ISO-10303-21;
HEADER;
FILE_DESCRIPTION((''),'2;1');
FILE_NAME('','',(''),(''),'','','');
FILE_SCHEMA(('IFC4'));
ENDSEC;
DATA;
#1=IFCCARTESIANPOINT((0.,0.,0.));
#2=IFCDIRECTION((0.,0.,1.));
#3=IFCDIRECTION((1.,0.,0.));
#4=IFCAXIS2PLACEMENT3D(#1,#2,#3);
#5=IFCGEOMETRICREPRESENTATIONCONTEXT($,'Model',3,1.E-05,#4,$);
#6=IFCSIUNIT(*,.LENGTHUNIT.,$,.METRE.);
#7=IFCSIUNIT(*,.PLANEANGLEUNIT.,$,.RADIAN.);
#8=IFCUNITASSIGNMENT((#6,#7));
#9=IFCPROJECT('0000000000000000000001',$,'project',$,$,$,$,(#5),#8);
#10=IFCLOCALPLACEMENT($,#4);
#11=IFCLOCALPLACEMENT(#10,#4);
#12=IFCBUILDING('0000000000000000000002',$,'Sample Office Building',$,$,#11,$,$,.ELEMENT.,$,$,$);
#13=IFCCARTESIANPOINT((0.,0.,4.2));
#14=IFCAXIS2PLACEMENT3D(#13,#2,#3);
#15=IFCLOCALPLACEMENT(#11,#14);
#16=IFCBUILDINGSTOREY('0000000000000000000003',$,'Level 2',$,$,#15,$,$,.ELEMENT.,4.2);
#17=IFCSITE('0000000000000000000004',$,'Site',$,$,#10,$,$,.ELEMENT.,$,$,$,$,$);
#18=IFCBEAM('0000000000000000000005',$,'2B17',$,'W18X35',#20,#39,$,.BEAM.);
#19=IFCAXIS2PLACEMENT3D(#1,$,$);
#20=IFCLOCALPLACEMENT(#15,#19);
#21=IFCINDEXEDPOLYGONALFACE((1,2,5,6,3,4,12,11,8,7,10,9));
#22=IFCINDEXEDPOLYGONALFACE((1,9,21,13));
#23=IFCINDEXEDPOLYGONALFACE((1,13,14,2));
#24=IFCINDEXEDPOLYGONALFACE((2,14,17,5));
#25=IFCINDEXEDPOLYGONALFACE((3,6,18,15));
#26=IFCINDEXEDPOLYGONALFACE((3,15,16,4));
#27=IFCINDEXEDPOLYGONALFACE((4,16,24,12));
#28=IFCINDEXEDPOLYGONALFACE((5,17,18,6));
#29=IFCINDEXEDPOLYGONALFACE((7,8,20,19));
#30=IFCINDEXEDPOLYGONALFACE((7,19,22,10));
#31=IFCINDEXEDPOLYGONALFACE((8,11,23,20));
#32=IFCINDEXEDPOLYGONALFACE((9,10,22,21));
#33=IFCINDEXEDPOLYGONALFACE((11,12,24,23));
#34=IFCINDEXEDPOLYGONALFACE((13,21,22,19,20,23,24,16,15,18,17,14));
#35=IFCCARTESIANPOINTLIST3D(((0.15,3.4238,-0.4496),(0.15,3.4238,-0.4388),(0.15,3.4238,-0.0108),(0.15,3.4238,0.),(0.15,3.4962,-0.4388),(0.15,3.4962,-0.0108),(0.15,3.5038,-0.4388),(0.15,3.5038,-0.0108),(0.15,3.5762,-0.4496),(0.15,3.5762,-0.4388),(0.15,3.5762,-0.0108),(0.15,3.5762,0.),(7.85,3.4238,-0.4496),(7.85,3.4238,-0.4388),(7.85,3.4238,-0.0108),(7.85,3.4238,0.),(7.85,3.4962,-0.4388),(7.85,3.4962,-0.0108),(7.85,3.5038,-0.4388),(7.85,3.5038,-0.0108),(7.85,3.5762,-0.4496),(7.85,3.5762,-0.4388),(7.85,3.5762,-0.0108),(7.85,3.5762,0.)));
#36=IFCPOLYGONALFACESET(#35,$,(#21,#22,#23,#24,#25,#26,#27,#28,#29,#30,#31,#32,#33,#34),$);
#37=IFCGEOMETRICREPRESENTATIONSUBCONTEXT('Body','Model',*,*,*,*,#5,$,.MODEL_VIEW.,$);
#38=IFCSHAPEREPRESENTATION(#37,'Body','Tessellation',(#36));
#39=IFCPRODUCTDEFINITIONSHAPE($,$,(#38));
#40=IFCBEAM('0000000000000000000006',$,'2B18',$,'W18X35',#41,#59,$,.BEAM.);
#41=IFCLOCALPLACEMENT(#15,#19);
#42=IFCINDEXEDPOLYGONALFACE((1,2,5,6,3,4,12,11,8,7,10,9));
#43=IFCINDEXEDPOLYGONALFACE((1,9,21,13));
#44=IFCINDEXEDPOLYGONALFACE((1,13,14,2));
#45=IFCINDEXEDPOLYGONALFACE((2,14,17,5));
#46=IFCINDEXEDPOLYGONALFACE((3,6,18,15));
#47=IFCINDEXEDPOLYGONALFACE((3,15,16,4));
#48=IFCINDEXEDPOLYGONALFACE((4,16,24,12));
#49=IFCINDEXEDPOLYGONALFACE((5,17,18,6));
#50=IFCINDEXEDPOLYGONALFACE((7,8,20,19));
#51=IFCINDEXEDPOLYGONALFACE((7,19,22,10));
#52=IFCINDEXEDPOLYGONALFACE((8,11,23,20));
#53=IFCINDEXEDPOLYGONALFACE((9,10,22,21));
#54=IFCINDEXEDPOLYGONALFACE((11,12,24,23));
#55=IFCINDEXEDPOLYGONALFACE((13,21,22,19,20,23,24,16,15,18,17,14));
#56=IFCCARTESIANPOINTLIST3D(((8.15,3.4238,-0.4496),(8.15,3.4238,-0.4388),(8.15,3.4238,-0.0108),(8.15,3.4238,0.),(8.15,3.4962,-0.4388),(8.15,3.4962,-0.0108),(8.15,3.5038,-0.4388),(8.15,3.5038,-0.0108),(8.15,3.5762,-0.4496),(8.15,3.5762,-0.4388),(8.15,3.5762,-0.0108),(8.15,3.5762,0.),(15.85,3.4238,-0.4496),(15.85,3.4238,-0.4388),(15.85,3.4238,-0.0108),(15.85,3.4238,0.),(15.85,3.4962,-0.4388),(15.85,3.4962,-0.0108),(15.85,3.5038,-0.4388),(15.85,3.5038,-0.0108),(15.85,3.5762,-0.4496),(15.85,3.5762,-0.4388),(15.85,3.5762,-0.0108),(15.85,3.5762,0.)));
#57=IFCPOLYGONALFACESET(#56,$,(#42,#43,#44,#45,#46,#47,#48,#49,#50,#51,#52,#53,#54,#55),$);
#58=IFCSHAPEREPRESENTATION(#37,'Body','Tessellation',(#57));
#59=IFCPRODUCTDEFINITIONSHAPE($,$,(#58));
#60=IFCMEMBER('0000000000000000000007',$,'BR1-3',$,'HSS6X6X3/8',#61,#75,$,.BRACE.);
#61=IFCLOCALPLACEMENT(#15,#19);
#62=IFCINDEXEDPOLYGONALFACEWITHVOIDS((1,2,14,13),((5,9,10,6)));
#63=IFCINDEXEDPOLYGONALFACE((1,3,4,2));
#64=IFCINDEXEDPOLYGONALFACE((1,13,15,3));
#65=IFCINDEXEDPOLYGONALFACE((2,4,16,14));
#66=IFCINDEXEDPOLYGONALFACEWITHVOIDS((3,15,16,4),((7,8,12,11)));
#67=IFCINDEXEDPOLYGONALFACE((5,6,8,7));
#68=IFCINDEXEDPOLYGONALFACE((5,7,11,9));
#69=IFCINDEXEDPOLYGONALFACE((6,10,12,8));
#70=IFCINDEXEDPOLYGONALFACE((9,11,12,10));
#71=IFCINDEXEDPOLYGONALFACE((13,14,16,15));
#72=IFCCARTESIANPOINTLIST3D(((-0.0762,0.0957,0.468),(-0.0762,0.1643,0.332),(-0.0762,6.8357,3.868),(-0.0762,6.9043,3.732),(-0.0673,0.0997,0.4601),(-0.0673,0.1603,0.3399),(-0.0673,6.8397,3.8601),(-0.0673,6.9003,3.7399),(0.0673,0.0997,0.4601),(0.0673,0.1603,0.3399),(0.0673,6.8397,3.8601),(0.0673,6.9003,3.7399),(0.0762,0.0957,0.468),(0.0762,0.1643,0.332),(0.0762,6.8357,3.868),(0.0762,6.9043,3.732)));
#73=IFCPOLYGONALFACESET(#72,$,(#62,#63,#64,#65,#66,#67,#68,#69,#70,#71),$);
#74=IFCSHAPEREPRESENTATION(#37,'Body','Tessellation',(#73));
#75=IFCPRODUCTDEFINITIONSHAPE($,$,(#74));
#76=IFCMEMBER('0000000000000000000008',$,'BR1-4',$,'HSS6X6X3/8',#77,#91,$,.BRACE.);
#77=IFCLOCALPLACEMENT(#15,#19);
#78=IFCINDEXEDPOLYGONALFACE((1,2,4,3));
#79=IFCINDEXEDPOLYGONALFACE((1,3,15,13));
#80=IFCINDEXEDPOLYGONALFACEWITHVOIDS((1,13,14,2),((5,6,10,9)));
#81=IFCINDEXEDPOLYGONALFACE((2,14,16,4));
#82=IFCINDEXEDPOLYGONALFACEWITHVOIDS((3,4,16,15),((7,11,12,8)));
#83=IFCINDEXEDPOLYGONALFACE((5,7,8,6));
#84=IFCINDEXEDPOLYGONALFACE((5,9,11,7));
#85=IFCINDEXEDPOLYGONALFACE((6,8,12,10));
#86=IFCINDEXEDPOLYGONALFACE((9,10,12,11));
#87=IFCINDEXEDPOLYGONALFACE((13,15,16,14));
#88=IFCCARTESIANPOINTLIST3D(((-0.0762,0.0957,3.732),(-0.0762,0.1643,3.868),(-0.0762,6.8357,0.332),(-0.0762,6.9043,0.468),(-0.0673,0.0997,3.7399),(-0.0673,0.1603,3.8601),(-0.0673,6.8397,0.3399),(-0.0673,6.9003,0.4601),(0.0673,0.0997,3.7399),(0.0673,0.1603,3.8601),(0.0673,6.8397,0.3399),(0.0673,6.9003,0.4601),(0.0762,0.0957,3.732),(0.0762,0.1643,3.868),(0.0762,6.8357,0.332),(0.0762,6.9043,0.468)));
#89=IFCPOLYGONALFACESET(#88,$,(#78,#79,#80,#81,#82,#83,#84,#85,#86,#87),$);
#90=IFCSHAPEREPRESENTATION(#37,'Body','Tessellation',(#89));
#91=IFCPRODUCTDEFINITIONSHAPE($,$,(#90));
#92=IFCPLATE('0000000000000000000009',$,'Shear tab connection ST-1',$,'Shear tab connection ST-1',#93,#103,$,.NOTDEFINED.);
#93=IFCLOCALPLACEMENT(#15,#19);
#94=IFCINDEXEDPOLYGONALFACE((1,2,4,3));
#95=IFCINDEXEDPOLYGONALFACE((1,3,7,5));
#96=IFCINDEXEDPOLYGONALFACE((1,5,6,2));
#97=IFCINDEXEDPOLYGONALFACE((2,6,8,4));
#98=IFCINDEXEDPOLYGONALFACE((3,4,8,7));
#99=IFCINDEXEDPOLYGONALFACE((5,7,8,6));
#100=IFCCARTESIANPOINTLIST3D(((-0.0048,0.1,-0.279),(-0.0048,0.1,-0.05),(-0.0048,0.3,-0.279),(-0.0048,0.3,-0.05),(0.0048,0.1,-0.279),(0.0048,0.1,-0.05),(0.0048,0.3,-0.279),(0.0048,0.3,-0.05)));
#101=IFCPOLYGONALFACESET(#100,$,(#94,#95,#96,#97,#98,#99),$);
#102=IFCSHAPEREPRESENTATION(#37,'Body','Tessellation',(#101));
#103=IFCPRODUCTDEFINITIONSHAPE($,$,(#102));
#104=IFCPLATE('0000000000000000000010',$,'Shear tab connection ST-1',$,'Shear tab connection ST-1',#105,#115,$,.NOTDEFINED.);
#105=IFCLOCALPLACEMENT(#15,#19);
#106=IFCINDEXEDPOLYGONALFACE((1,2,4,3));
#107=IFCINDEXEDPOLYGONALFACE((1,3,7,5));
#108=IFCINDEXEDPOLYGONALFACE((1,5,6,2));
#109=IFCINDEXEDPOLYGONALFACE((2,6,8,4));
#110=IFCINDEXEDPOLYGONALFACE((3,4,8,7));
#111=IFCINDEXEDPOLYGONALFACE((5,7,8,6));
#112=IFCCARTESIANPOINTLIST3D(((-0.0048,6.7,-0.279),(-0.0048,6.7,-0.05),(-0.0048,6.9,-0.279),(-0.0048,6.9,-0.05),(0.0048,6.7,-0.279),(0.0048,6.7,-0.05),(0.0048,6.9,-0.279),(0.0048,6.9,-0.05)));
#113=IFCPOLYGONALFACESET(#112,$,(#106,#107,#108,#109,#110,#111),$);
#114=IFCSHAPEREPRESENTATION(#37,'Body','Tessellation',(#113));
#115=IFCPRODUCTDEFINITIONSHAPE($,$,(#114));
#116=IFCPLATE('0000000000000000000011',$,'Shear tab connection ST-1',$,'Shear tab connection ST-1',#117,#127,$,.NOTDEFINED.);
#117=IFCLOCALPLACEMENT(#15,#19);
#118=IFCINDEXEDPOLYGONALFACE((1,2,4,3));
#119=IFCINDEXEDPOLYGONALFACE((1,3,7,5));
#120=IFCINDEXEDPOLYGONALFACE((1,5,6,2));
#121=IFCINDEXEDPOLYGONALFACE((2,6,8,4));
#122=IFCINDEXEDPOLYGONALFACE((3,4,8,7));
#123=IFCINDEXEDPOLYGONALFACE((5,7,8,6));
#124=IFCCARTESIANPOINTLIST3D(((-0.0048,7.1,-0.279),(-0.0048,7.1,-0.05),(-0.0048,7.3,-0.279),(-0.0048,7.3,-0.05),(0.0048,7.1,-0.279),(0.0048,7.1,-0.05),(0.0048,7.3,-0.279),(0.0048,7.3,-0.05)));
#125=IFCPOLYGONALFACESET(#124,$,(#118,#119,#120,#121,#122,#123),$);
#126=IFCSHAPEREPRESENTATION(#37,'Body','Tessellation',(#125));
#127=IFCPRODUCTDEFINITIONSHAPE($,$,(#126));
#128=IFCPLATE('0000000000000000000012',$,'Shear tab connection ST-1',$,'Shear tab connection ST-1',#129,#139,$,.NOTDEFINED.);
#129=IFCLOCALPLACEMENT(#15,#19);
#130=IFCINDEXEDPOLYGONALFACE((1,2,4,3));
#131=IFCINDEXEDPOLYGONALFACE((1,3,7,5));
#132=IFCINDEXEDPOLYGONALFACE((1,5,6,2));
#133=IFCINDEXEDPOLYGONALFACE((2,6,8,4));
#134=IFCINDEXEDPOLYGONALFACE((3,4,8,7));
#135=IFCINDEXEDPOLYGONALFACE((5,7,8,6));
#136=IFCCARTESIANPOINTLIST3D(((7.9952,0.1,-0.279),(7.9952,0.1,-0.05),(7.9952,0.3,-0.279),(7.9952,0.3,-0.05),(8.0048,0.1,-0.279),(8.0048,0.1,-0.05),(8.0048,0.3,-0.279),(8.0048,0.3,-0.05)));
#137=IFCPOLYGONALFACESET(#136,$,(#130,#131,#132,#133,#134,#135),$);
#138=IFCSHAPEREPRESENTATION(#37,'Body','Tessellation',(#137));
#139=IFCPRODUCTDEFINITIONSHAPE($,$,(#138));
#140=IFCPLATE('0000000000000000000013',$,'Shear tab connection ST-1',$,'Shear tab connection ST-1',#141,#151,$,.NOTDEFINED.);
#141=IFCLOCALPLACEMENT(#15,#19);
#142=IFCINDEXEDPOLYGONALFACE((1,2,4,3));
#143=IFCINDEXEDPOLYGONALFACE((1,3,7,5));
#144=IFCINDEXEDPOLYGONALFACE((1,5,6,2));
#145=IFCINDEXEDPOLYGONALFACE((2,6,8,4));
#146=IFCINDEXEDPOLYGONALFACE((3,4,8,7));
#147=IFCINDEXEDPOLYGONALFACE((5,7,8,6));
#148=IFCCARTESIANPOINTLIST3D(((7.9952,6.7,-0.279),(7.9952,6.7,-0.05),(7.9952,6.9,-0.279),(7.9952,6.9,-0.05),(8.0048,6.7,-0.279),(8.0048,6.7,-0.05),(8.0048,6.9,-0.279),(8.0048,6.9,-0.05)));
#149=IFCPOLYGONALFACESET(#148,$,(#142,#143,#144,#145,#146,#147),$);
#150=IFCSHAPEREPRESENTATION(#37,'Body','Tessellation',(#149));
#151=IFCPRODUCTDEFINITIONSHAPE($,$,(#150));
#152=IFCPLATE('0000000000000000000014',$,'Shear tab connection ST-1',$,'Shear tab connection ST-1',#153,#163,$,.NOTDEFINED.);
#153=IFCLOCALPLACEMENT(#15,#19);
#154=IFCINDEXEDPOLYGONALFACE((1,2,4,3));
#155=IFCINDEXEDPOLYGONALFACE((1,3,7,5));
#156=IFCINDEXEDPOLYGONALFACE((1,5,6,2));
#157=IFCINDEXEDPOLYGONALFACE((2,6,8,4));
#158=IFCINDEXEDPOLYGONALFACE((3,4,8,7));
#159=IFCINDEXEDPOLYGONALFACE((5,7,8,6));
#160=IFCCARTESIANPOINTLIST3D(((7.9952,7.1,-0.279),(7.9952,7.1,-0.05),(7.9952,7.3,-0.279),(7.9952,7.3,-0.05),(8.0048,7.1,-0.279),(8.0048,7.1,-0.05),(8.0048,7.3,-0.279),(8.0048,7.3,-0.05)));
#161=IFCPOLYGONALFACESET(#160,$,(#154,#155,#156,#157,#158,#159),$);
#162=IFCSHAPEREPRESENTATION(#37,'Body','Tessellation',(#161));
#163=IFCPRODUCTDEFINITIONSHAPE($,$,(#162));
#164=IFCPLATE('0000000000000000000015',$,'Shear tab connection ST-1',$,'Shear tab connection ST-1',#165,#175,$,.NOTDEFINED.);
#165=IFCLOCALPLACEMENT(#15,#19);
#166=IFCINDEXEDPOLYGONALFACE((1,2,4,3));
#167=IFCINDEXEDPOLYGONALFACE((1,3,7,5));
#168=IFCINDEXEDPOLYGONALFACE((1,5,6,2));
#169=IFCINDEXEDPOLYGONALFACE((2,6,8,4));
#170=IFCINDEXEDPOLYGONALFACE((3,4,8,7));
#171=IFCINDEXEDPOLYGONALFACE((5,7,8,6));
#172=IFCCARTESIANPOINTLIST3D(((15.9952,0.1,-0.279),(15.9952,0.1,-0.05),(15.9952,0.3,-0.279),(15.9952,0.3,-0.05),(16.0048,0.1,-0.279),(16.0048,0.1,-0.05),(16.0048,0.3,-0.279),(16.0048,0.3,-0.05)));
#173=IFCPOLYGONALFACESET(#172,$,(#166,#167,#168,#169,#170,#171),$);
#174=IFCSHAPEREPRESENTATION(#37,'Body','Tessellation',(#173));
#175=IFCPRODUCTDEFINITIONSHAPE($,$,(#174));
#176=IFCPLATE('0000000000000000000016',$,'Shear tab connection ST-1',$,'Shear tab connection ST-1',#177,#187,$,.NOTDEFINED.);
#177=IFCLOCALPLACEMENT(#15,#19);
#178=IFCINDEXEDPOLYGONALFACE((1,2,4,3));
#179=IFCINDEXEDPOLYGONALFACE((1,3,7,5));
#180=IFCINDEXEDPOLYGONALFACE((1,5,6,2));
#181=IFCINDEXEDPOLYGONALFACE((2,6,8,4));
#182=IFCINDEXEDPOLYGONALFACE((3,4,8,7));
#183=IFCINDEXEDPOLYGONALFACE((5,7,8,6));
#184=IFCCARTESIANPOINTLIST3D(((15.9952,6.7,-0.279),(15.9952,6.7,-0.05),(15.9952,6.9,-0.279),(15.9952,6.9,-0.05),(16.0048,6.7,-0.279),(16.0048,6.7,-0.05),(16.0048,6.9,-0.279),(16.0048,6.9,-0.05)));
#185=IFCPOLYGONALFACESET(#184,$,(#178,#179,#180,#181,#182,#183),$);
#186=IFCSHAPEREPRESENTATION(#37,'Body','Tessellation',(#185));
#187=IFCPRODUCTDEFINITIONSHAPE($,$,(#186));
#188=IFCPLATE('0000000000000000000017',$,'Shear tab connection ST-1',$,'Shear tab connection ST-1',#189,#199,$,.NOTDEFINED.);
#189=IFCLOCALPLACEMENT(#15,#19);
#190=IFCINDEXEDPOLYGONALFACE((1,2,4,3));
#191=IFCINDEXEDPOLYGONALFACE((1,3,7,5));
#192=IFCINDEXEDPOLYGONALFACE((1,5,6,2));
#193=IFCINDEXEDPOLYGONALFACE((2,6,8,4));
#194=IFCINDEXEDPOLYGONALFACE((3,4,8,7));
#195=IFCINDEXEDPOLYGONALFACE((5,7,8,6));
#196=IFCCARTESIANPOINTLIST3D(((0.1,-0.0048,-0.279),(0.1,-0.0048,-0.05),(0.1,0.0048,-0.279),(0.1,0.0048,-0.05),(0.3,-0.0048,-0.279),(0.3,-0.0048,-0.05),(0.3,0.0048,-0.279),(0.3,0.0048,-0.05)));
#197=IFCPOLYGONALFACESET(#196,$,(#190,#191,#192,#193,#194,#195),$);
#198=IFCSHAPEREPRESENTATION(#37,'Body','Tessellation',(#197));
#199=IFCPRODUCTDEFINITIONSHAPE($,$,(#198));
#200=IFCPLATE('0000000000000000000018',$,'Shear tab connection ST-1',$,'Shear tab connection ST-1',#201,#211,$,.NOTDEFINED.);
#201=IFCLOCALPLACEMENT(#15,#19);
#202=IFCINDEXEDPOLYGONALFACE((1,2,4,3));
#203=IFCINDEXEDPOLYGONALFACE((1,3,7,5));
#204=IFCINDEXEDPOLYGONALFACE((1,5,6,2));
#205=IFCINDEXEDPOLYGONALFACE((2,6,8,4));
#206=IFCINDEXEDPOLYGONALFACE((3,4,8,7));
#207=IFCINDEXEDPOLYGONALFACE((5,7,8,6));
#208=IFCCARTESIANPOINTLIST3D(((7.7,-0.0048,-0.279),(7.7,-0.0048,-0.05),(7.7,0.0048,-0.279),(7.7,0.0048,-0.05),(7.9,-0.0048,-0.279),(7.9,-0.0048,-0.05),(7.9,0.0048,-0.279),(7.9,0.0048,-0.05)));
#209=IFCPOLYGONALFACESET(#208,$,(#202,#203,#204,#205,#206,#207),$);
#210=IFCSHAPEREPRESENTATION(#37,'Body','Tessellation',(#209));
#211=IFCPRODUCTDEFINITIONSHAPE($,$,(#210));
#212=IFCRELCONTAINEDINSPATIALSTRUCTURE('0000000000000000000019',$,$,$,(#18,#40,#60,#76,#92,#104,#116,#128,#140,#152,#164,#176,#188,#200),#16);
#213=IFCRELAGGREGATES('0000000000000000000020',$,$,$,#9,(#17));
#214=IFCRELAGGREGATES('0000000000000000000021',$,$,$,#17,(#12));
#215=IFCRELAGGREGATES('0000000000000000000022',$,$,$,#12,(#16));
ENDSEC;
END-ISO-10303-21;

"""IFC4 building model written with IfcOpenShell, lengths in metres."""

from ifc_helpers import new_model, si_unit, frame, origin_with_axes, place, context, subcontext, project, spatial, rectangle, hollow_rectangle, i_section, extrude, element, save


model = new_model("IFC4")

# Units and contexts
model_context = context("Model", 3, precision=1e-05, world=origin_with_axes())
body_context = subcontext(model_context, "Body", "Model", "MODEL_VIEW")
ifc_project = project(units=[si_unit("LENGTHUNIT", "METRE"), si_unit("PLANEANGLEUNIT", "RADIAN")], contexts=[model_context])

# Site, building, storey
site_placement = place(None, origin_with_axes())
site = spatial("IfcSite", under=ifc_project, at=site_placement, Name="Site", CompositionType="ELEMENT")
building_placement = place(site_placement, origin_with_axes())
building = spatial("IfcBuilding", under=site, at=building_placement, Name="Sample Office Building", CompositionType="ELEMENT")
storey_placement = place(building_placement, frame((0.0, 0.0, 4.2), z_axis=(0.0, 0.0, 1.0), x_axis=(1.0, 0.0, 0.0)))
storey = spatial("IfcBuildingStorey", under=building, at=storey_placement, Name="Level 2", CompositionType="ELEMENT", Elevation=4.2)

# Beams
for number, where, z_axis, x_axis, name in (
    (1, (0.15, 3.5, 3.9752), (1.0, 0.0, 0.0), (0.0, 1.0, 0.0), "2B17"),
    (2, (8.15, 3.5, 3.9752), (1.0, 0.0, 0.0), (0.0, 1.0, 0.0), "2B18"),
):
    element("IfcBeam", number, at=place(None, frame(where, z_axis=z_axis, x_axis=x_axis)), inside=storey, Name=name, ObjectType="W18X35", PredefinedType="BEAM", context=body_context, shape_type="SweptSolid", body=[
        extrude(i_section(OverallWidth=0.1524, OverallDepth=0.4496, WebThickness=0.0076, FlangeThickness=0.0108), None, (0.0, 0.0, 1.0), 7.7),
    ])

# Members
for number, where, z_axis, x_axis, name in (
    (3, (0.0, 0.13, 4.6), (0.0, 0.892832, 0.45039), (-1.0, 0.0, 0.0), "BR1-3"),
    (4, (0.0, 6.87, 4.6), (0.0, -0.892832, 0.45039), (1.0, 0.0, 0.0), "BR1-4"),
):
    element("IfcMember", number, at=place(None, frame(where, z_axis=z_axis, x_axis=x_axis)), inside=storey, Name=name, ObjectType="HSS6X6X3/8", PredefinedType="BRACE", context=body_context, shape_type="SweptSolid", body=[
        extrude(hollow_rectangle(XDim=0.1524, YDim=0.1524, WallThickness=0.0089), None, (0.0, 0.0, 1.0), 7.549),
    ])

# Plates
plate_1_placement = place(None, frame((0.0, 0.2, 3.921), z_axis=(0.0, 0.0, 1.0), x_axis=(1.0, 0.0, 0.0)))
element("IfcPlate", 5, at=plate_1_placement, inside=storey, Name="Shear tab connection ST-1", ObjectType="Shear tab connection ST-1", PredefinedType="NOTDEFINED", context=body_context, shape_type="SweptSolid", body=[
    extrude(rectangle(XDim=0.0095, YDim=0.2), None, (0.0, 0.0, 1.0), 0.229),
])
for number, where, z_axis, x_axis, name in (
    (6, (0.0, 6.8, 3.921), (0.0, 0.0, 1.0), (1.0, 0.0, 0.0), "Shear tab connection ST-1"),
    (7, (0.0, 7.2, 3.921), (0.0, 0.0, 1.0), (1.0, 0.0, 0.0), "Shear tab connection ST-1"),
):
    element("IfcPlate", number, at=place(None, frame(where, z_axis=z_axis, x_axis=x_axis)), inside=storey, Name=name, ObjectType="Shear tab connection ST-1", PredefinedType="NOTDEFINED", context=body_context, shape_type="SweptSolid", body=[
        extrude(rectangle(XDim=0.0095, YDim=0.2), None, (0.0, 0.0, 1.0), 0.229),
    ])
plate_2_placement = place(None, frame((8.0, 0.2, 3.921), z_axis=(0.0, 0.0, 1.0), x_axis=(1.0, 0.0, 0.0)))
element("IfcPlate", 8, at=plate_2_placement, inside=storey, Name="Shear tab connection ST-1", ObjectType="Shear tab connection ST-1", PredefinedType="NOTDEFINED", context=body_context, shape_type="SweptSolid", body=[
    extrude(rectangle(XDim=0.0095, YDim=0.2), None, (0.0, 0.0, 1.0), 0.229),
])
for number, where, z_axis, x_axis, name in (
    (9, (8.0, 6.8, 3.921), (0.0, 0.0, 1.0), (1.0, 0.0, 0.0), "Shear tab connection ST-1"),
    (10, (8.0, 7.2, 3.921), (0.0, 0.0, 1.0), (1.0, 0.0, 0.0), "Shear tab connection ST-1"),
):
    element("IfcPlate", number, at=place(None, frame(where, z_axis=z_axis, x_axis=x_axis)), inside=storey, Name=name, ObjectType="Shear tab connection ST-1", PredefinedType="NOTDEFINED", context=body_context, shape_type="SweptSolid", body=[
        extrude(rectangle(XDim=0.0095, YDim=0.2), None, (0.0, 0.0, 1.0), 0.229),
    ])
plate_3_placement = place(None, frame((16.0, 0.2, 3.921), z_axis=(0.0, 0.0, 1.0), x_axis=(1.0, 0.0, 0.0)))
element("IfcPlate", 11, at=plate_3_placement, inside=storey, Name="Shear tab connection ST-1", ObjectType="Shear tab connection ST-1", PredefinedType="NOTDEFINED", context=body_context, shape_type="SweptSolid", body=[
    extrude(rectangle(XDim=0.0095, YDim=0.2), None, (0.0, 0.0, 1.0), 0.229),
])
plate_4_placement = place(None, frame((16.0, 6.8, 3.921), z_axis=(0.0, 0.0, 1.0), x_axis=(1.0, 0.0, 0.0)))
element("IfcPlate", 12, at=plate_4_placement, inside=storey, Name="Shear tab connection ST-1", ObjectType="Shear tab connection ST-1", PredefinedType="NOTDEFINED", context=body_context, shape_type="SweptSolid", body=[
    extrude(rectangle(XDim=0.0095, YDim=0.2), None, (0.0, 0.0, 1.0), 0.229),
])
plate_5_placement = place(None, frame((0.2, 0.0, 3.921), z_axis=(0.0, 0.0, 1.0), x_axis=(1.0, 0.0, 0.0)))
element("IfcPlate", 13, at=plate_5_placement, inside=storey, Name="Shear tab connection ST-1", ObjectType="Shear tab connection ST-1", PredefinedType="NOTDEFINED", context=body_context, shape_type="SweptSolid", body=[
    extrude(rectangle(XDim=0.2, YDim=0.0095), None, (0.0, 0.0, 1.0), 0.229),
])
plate_6_placement = place(None, frame((7.8, 0.0, 3.921), z_axis=(0.0, 0.0, 1.0), x_axis=(1.0, 0.0, 0.0)))
element("IfcPlate", 14, at=plate_6_placement, inside=storey, Name="Shear tab connection ST-1", ObjectType="Shear tab connection ST-1", PredefinedType="NOTDEFINED", context=body_context, shape_type="SweptSolid", body=[
    extrude(rectangle(XDim=0.2, YDim=0.0095), None, (0.0, 0.0, 1.0), 0.229),
])

save(model, "model.ifc")
